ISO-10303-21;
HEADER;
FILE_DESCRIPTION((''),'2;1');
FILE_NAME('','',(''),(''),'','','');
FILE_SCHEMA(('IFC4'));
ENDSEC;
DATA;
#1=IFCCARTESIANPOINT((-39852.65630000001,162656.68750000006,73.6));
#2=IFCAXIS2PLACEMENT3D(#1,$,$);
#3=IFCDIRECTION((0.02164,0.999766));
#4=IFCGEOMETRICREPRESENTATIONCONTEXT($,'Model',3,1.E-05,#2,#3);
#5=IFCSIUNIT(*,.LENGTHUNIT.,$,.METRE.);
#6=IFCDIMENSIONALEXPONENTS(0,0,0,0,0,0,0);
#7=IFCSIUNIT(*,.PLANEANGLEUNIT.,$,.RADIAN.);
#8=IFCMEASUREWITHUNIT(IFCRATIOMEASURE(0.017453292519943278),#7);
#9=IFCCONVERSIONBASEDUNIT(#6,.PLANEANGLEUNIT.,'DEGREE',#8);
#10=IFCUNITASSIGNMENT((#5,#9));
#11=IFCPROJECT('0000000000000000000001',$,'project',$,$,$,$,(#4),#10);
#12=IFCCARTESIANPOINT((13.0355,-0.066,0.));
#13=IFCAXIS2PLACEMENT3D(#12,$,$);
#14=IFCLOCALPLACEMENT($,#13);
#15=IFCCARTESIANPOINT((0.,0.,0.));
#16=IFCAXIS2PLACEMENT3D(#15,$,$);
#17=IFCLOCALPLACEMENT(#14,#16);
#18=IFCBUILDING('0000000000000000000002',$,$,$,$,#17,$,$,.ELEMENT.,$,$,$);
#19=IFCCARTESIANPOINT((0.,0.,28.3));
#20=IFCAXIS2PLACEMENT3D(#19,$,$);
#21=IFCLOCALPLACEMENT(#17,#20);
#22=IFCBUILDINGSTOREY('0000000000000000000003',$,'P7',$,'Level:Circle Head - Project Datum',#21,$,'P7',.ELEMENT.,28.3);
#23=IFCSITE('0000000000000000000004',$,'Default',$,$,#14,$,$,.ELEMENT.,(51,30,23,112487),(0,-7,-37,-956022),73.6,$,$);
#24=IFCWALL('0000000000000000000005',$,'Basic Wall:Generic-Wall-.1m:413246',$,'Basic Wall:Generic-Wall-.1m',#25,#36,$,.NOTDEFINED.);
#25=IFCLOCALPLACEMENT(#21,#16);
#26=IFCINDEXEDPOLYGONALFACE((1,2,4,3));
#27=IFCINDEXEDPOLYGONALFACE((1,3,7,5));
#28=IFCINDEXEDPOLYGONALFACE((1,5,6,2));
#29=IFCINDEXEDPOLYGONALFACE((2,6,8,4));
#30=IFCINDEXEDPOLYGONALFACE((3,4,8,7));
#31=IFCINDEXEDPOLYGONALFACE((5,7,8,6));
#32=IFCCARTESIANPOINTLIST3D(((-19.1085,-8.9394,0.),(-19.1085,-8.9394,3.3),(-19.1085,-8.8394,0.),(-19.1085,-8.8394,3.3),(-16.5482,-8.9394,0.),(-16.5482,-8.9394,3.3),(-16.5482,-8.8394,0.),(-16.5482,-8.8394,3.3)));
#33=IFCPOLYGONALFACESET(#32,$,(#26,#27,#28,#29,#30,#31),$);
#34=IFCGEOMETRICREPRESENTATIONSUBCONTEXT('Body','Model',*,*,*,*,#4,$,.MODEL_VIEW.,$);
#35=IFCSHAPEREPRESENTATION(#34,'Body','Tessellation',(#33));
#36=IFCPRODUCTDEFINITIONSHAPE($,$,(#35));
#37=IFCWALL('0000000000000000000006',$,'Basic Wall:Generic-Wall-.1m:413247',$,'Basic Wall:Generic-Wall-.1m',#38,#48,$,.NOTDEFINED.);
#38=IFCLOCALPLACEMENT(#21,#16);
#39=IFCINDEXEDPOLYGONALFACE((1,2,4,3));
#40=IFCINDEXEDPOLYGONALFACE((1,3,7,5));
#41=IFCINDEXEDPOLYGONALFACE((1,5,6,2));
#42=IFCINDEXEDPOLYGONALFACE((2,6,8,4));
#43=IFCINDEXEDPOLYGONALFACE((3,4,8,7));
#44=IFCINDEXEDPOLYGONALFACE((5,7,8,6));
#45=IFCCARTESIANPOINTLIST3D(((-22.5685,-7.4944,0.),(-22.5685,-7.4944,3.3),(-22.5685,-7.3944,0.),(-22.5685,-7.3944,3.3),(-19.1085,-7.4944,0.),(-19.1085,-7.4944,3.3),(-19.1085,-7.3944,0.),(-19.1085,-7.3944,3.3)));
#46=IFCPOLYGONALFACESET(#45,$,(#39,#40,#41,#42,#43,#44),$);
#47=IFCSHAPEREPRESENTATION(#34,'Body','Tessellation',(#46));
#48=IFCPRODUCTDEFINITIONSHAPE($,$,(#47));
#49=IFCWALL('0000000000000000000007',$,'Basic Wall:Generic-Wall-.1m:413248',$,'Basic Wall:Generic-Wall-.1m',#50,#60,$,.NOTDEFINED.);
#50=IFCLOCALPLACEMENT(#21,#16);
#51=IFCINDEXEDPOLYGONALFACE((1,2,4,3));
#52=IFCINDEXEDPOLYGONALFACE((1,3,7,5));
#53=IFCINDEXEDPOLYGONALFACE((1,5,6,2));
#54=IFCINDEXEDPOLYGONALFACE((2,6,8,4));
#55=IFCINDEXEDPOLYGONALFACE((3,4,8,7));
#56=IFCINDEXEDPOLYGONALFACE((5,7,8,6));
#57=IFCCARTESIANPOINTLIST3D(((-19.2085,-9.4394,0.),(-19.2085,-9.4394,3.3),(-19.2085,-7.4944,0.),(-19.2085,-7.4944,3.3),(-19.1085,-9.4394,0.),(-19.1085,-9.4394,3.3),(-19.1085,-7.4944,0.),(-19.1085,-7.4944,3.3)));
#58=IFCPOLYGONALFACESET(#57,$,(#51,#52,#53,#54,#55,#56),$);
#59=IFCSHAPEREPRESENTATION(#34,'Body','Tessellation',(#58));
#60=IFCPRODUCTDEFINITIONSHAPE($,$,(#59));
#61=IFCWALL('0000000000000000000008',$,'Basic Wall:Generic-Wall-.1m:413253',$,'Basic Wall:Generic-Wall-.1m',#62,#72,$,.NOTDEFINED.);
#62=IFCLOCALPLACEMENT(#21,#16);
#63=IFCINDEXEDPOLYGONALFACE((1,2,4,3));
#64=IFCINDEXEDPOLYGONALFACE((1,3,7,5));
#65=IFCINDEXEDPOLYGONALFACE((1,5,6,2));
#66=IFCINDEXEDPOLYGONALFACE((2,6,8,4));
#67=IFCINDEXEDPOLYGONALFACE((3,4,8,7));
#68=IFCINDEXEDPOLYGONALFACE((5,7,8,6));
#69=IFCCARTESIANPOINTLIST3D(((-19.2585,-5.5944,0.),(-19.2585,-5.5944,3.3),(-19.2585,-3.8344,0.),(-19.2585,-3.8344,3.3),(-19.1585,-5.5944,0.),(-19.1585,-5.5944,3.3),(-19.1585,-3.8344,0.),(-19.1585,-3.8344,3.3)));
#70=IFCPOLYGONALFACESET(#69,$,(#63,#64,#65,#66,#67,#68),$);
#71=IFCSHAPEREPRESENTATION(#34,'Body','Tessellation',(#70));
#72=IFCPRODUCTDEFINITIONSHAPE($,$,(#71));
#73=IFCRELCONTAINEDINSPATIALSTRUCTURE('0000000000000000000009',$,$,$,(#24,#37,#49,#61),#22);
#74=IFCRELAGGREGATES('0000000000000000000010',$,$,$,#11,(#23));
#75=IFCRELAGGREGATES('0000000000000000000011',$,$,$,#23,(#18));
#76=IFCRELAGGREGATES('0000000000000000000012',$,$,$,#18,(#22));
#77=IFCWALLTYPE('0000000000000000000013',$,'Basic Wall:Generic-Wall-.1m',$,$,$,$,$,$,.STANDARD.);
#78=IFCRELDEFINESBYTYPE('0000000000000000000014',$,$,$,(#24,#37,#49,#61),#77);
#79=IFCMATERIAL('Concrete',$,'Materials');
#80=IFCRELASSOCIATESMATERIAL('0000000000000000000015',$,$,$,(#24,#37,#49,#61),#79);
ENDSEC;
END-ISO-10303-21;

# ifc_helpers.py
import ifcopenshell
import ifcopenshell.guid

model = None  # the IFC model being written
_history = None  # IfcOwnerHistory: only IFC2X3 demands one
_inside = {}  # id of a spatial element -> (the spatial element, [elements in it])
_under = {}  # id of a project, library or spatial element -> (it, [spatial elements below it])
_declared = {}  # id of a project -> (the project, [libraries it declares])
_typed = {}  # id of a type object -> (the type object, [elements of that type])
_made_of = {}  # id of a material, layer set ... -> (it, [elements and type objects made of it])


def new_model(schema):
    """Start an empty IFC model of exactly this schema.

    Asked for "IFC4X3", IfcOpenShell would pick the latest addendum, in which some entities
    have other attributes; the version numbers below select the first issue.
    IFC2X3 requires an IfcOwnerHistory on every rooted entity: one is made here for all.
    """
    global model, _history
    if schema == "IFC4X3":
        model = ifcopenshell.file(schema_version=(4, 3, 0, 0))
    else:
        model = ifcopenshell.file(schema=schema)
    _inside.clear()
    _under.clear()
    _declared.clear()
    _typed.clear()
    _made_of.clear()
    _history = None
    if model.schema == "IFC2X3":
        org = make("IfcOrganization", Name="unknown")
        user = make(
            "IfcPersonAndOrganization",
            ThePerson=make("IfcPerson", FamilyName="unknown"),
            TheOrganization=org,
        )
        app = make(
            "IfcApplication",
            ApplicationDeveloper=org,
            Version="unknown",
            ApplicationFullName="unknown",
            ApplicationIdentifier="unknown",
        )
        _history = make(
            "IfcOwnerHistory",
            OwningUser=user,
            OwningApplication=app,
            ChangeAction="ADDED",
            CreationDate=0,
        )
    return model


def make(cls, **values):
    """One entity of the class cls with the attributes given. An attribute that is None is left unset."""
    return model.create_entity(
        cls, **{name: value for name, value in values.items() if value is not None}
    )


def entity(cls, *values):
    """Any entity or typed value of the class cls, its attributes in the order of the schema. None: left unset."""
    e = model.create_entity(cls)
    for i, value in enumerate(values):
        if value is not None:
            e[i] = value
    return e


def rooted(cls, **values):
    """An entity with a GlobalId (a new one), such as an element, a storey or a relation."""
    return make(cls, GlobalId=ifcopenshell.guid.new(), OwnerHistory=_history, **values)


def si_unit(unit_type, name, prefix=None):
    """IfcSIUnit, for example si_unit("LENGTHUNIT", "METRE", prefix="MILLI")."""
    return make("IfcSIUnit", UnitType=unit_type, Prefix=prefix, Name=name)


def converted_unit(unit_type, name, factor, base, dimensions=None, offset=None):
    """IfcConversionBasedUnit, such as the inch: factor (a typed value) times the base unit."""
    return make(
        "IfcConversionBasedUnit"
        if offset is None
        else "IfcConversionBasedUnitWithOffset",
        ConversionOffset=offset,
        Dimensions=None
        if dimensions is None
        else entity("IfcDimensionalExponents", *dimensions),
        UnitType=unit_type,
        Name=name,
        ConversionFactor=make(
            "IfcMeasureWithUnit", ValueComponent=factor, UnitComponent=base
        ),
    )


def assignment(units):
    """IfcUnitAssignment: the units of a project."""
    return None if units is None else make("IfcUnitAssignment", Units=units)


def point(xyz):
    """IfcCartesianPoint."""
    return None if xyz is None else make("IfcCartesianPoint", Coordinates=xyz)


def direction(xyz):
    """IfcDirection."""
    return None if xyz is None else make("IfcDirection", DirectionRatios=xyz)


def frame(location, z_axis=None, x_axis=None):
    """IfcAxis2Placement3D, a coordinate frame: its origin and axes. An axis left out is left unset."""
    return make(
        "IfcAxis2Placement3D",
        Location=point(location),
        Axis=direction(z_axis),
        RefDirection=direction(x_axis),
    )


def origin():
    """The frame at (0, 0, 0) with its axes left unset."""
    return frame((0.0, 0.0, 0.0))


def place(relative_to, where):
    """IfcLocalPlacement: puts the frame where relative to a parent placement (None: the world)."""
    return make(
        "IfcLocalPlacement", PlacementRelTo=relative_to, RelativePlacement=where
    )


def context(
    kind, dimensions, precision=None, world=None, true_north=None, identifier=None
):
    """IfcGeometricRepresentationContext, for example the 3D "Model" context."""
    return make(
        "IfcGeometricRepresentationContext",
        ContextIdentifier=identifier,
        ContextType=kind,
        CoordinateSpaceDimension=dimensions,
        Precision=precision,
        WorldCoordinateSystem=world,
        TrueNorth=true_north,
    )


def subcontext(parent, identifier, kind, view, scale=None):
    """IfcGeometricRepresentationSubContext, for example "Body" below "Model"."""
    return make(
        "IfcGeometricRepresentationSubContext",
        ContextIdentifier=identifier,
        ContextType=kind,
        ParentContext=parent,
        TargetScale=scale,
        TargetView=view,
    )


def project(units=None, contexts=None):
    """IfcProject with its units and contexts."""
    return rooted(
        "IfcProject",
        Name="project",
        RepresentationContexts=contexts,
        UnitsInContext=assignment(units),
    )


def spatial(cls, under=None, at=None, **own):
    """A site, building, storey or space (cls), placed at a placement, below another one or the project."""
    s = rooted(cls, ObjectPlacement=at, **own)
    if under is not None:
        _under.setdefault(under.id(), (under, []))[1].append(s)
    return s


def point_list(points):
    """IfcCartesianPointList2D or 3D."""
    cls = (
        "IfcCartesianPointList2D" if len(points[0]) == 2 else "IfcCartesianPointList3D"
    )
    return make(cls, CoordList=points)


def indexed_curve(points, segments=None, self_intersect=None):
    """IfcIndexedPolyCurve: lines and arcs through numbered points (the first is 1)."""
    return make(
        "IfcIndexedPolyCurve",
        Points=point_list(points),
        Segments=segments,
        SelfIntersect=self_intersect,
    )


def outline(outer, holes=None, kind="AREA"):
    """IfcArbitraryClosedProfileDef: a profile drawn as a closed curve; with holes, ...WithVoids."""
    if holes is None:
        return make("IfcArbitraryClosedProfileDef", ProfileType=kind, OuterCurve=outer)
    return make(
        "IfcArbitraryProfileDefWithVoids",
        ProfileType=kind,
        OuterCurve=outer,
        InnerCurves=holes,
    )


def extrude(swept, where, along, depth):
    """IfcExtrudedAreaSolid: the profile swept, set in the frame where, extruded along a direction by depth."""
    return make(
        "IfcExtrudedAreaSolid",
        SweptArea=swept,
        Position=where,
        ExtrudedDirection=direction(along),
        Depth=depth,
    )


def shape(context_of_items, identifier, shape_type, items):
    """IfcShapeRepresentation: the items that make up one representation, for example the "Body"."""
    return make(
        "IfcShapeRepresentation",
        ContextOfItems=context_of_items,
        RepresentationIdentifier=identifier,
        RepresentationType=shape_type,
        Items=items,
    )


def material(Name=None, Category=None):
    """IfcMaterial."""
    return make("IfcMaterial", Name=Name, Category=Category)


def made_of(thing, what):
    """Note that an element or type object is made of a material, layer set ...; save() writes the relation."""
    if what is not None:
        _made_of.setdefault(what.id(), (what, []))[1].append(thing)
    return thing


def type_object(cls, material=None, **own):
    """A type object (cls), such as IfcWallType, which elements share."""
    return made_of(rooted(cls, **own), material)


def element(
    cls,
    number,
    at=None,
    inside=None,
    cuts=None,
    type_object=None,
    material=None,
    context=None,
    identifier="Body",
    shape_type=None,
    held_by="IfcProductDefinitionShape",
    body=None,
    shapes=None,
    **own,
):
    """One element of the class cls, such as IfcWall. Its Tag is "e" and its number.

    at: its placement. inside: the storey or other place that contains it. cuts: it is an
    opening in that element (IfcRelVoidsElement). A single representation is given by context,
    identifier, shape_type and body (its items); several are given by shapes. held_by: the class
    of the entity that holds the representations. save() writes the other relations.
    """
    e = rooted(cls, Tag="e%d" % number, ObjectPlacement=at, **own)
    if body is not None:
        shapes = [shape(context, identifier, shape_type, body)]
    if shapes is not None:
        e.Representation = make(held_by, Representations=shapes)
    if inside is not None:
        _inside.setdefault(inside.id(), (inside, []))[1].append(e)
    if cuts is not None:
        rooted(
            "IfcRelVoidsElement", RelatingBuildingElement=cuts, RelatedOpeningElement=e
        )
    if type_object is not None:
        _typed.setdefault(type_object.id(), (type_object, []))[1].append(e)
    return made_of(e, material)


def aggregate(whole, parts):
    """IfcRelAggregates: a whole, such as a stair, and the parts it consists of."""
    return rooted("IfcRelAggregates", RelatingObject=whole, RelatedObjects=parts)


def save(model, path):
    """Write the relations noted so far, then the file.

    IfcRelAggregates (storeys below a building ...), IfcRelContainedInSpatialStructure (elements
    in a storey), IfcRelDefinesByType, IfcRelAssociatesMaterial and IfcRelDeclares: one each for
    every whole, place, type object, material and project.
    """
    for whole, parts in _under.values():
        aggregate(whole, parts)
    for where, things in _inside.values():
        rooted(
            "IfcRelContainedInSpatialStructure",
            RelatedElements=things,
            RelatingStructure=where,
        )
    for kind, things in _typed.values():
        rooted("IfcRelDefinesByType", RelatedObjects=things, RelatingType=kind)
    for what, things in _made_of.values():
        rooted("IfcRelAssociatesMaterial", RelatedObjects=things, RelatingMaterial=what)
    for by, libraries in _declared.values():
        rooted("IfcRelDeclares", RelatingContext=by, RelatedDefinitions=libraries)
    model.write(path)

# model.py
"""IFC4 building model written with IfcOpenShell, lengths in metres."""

from ifc_helpers import new_model, entity, si_unit, converted_unit, direction, frame, origin, place, context, subcontext, project, spatial, indexed_curve, outline, extrude, material, type_object, element, save


model = new_model("IFC4")

# Units and contexts
model_context = context("Model", 3, precision=1e-05, world=frame((-39852.65630000001, 162656.68750000006, 73.6)), true_north=direction((0.02164, 0.999766)))
body_context = subcontext(model_context, "Body", "Model", "MODEL_VIEW")
ifc_project = project(units=[si_unit("LENGTHUNIT", "METRE"), converted_unit("PLANEANGLEUNIT", "DEGREE", entity("IfcRatioMeasure", 0.017453292519943278), si_unit("PLANEANGLEUNIT", "RADIAN"), dimensions=[0, 0, 0, 0, 0, 0, 0])], contexts=[model_context])

# Site, building, storey
site_placement = place(None, frame((13.0355, -0.066, 0.0)))
site = spatial("IfcSite", under=ifc_project, at=site_placement, Name="Default", CompositionType="ELEMENT", RefLatitude=(51, 30, 23, 112487), RefLongitude=(0, -7, -37, -956022), RefElevation=73.6)
building_placement = place(site_placement, origin())
building = spatial("IfcBuilding", under=site, at=building_placement, CompositionType="ELEMENT")
storey_placement = place(building_placement, frame((0.0, 0.0, 28.3)))
storey = spatial("IfcBuildingStorey", under=building, at=storey_placement, Name="P7", ObjectType="Level:Circle Head - Project Datum", LongName="P7", CompositionType="ELEMENT", Elevation=28.3)

# Shared definitions
ifc_material = material(Name="Concrete", Category="Materials")

# Walls
wall_type = type_object("IfcWallType", Name="Basic Wall:Generic-Wall-.1m", PredefinedType="STANDARD")
wall_1_placement = place(storey_placement, frame((-19.1085, -8.8894, 0.0)))
element("IfcWall", 1, at=wall_1_placement, inside=storey, type_object=wall_type, material=ifc_material, Name="Basic Wall:Generic-Wall-.1m:413246", ObjectType="Basic Wall:Generic-Wall-.1m", PredefinedType="NOTDEFINED", context=body_context, shape_type="SweptSolid", body=[
    extrude(outline(indexed_curve([(2.5602, 0.05), (0.0, 0.05), (0.0, -0.05), (2.5602, -0.05), (2.5602, 0.05)], self_intersect=False)), origin(), (0.0, 0.0, 1.0), 3.3),
])
wall_2_placement = place(storey_placement, frame((-22.5685, -7.4444, 0.0)))
element("IfcWall", 2, at=wall_2_placement, inside=storey, type_object=wall_type, material=ifc_material, Name="Basic Wall:Generic-Wall-.1m:413247", ObjectType="Basic Wall:Generic-Wall-.1m", PredefinedType="NOTDEFINED", context=body_context, shape_type="SweptSolid", body=[
    extrude(outline(indexed_curve([(3.46, 0.05), (0.0, 0.05), (0.0, -0.05), (3.46, -0.05), (3.46, 0.05)], self_intersect=False)), origin(), (0.0, 0.0, 1.0), 3.3),
])
wall_3_placement = place(storey_placement, frame((-19.1585, -7.4944, 0.0), z_axis=(0.0, 0.0, 1.0), x_axis=(0.0, -1.0, 0.0)))
element("IfcWall", 3, at=wall_3_placement, inside=storey, type_object=wall_type, material=ifc_material, Name="Basic Wall:Generic-Wall-.1m:413248", ObjectType="Basic Wall:Generic-Wall-.1m", PredefinedType="NOTDEFINED", context=body_context, shape_type="SweptSolid", body=[
    extrude(outline(indexed_curve([(1.945, 0.05), (0.0, 0.05), (0.0, -0.05), (1.945, -0.05), (1.945, 0.05)], self_intersect=False)), origin(), (0.0, 0.0, 1.0), 3.3),
])
wall_4_placement = place(storey_placement, frame((-19.2085, -5.5944, 0.0), z_axis=(0.0, 0.0, 1.0), x_axis=(0.0, 1.0, 0.0)))
element("IfcWall", 4, at=wall_4_placement, inside=storey, type_object=wall_type, material=ifc_material, Name="Basic Wall:Generic-Wall-.1m:413253", ObjectType="Basic Wall:Generic-Wall-.1m", PredefinedType="NOTDEFINED", context=body_context, shape_type="SweptSolid", body=[
    extrude(outline(indexed_curve([(1.76, 0.05), (0.0, 0.05), (0.0, -0.05), (1.76, -0.05), (1.76, 0.05)], self_intersect=False)), origin(), (0.0, 0.0, 1.0), 3.3),
])

save(model, "model.ifc")
